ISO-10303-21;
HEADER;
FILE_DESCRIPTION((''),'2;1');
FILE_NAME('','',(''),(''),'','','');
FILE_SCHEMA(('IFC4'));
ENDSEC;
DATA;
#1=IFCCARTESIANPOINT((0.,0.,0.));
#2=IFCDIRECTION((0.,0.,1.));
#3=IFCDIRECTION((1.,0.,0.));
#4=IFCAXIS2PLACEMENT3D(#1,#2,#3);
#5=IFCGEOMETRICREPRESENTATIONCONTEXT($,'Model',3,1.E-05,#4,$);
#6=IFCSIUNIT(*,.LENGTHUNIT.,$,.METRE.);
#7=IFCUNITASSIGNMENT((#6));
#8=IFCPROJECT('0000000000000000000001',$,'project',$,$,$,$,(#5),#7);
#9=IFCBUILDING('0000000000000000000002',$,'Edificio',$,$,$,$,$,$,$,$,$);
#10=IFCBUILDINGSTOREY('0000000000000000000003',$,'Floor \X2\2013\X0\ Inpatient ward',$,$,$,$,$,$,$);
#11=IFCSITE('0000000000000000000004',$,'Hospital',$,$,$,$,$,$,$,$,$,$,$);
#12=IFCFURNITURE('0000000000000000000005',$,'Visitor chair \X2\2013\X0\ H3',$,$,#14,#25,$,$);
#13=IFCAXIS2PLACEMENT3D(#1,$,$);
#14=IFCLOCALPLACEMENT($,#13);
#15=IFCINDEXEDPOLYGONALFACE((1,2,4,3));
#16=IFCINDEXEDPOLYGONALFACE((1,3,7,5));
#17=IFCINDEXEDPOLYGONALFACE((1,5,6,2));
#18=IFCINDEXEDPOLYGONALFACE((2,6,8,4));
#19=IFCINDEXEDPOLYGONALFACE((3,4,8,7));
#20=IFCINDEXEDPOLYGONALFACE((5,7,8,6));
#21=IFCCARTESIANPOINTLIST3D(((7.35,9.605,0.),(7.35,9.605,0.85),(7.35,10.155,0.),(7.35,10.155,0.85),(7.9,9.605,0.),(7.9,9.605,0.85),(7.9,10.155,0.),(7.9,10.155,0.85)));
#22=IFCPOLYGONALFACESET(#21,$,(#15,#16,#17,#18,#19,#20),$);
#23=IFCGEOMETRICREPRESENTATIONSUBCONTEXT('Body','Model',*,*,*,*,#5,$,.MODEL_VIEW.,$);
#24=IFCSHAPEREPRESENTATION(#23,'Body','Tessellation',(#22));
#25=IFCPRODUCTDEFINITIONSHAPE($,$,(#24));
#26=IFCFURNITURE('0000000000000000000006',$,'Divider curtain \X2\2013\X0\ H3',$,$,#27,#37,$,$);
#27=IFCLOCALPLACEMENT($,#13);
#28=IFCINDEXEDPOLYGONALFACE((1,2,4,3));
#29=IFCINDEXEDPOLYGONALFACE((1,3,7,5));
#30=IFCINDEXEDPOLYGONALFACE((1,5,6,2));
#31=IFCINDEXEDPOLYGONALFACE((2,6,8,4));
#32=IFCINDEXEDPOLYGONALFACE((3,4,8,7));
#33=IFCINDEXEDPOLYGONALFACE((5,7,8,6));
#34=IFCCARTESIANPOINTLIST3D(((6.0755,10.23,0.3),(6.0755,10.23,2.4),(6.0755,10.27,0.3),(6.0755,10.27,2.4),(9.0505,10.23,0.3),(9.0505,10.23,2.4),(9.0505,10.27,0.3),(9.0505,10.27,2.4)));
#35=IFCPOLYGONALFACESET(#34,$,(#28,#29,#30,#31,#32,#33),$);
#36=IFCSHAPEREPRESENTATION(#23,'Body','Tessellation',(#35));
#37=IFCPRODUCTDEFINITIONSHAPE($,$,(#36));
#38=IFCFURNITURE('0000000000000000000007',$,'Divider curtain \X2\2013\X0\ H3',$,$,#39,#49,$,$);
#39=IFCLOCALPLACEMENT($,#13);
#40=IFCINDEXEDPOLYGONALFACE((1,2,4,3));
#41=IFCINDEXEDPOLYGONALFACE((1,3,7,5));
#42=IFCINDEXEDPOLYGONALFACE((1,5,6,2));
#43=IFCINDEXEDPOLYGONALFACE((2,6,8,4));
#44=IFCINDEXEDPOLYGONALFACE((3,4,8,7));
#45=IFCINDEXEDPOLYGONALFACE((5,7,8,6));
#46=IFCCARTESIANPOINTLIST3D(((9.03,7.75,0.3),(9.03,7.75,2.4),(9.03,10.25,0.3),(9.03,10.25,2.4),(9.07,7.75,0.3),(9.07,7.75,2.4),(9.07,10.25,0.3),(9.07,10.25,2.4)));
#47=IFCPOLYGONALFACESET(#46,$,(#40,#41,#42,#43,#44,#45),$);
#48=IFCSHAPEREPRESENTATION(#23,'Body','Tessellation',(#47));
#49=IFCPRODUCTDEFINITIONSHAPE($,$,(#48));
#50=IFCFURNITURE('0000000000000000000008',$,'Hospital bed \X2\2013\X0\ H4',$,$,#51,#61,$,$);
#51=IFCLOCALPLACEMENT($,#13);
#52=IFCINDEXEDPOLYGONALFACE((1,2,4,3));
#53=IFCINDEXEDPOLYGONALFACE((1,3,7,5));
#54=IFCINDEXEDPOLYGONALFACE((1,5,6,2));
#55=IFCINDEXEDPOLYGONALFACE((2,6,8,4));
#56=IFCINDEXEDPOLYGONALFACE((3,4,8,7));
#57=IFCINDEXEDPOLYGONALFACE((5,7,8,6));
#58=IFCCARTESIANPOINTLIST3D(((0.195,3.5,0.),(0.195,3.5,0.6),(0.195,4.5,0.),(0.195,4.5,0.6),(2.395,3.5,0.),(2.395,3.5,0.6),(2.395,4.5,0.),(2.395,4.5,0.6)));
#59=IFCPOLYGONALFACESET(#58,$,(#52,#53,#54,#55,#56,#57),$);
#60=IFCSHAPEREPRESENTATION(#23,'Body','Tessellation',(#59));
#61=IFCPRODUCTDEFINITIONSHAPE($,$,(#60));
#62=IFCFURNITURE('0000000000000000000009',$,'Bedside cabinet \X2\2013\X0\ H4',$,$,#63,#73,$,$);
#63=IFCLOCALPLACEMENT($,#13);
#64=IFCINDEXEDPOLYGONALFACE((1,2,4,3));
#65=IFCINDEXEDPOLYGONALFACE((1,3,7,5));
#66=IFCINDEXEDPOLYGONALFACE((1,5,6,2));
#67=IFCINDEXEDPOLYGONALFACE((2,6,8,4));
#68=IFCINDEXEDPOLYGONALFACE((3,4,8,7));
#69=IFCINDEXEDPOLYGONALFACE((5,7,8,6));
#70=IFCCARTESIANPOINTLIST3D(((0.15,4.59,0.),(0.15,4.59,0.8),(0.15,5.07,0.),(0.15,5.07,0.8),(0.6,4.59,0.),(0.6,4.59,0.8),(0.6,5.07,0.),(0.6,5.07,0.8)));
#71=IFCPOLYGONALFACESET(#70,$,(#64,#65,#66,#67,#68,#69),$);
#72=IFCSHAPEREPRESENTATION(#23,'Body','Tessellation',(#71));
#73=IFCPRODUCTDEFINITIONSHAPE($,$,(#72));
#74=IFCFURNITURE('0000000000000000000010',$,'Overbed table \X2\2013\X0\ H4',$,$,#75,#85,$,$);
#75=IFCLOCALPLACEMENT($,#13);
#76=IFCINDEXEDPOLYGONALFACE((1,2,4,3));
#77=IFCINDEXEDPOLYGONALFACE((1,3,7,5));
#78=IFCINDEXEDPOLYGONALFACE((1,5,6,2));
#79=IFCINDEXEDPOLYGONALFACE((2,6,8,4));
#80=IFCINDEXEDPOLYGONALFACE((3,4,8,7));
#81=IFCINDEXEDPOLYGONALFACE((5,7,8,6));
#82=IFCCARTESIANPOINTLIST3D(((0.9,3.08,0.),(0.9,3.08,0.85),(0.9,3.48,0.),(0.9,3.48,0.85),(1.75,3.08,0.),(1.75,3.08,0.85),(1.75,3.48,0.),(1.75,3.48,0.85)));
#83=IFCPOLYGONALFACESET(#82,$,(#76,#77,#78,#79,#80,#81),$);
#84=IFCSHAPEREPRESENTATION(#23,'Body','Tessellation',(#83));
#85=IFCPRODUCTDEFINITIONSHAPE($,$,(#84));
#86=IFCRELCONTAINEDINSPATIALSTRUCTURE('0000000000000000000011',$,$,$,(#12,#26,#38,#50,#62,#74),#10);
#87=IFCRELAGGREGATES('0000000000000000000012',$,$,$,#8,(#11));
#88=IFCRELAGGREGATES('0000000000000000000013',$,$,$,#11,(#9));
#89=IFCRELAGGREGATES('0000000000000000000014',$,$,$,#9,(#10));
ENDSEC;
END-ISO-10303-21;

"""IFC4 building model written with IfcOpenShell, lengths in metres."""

from ifc_helpers import new_model, si_unit, frame, origin_with_axes, context, subcontext, project, spatial, line, indexed_curve, outline, extrude, element, save


model = new_model("IFC4")

# Units and contexts
model_context = context("Model", 3, precision=1e-05, world=origin_with_axes())
body_context = subcontext(model_context, "Body", "Model", "MODEL_VIEW")
ifc_project = project(units=[si_unit("LENGTHUNIT", "METRE")], contexts=[model_context])

# Site, building, storey
site = spatial("IfcSite", under=ifc_project, Name="Hospital")
building = spatial("IfcBuilding", under=site, Name="Edificio")
storey = spatial("IfcBuildingStorey", under=building, Name="Floor – Inpatient ward")

# Furniture
element("IfcFurniture", 1, inside=storey, Name="Visitor chair – H3", context=body_context, shape_type="SweptSolid", body=[
    extrude(outline(indexed_curve([(0.0, 0.0), (0.55, 0.0), (0.55, 0.55), (0.0, 0.55)], segments=[line(1, 2, 3, 4, 1)])), frame((7.35, 9.605, 0.0), z_axis=(0.0, 0.0, 1.0), x_axis=(1.0, 0.0, 0.0)), (0.0, 0.0, 1.0), 0.85),
])
element("IfcFurniture", 2, inside=storey, Name="Divider curtain – H3", context=body_context, shape_type="SweptSolid", body=[
    extrude(outline(indexed_curve([(0.0, 0.0), (2.975, 0.0), (2.975, 0.04), (0.0, 0.04)], segments=[line(1, 2, 3, 4, 1)])), frame((6.0755, 10.23, 0.3), z_axis=(0.0, 0.0, 1.0), x_axis=(1.0, 0.0, 0.0)), (0.0, 0.0, 1.0), 2.1),
])
element("IfcFurniture", 3, inside=storey, Name="Divider curtain – H3", context=body_context, shape_type="SweptSolid", body=[
    extrude(outline(indexed_curve([(0.0, 0.0), (0.04, 0.0), (0.04, 2.5), (0.0, 2.5)], segments=[line(1, 2, 3, 4, 1)])), frame((9.03, 7.75, 0.3), z_axis=(0.0, 0.0, 1.0), x_axis=(1.0, 0.0, 0.0)), (0.0, 0.0, 1.0), 2.1),
])
element("IfcFurniture", 4, inside=storey, Name="Hospital bed – H4", context=body_context, shape_type="SweptSolid", body=[
    extrude(outline(indexed_curve([(0.0, 0.0), (2.2, 0.0), (2.2, 1.0), (0.0, 1.0)], segments=[line(1, 2, 3, 4, 1)])), frame((0.195, 3.5, 0.0), z_axis=(0.0, 0.0, 1.0), x_axis=(1.0, 0.0, 0.0)), (0.0, 0.0, 1.0), 0.6),
])
element("IfcFurniture", 5, inside=storey, Name="Bedside cabinet – H4", context=body_context, shape_type="SweptSolid", body=[
    extrude(outline(indexed_curve([(0.0, 0.0), (0.45, 0.0), (0.45, 0.48), (0.0, 0.48)], segments=[line(1, 2, 3, 4, 1)])), frame((0.15, 4.59, 0.0), z_axis=(0.0, 0.0, 1.0), x_axis=(1.0, 0.0, 0.0)), (0.0, 0.0, 1.0), 0.8),
])
element("IfcFurniture", 6, inside=storey, Name="Overbed table – H4", context=body_context, shape_type="SweptSolid", body=[
    extrude(outline(indexed_curve([(0.0, 0.0), (0.85, 0.0), (0.85, 0.4), (0.0, 0.4)], segments=[line(1, 2, 3, 4, 1)])), frame((0.9, 3.08, 0.0), z_axis=(0.0, 0.0, 1.0), x_axis=(1.0, 0.0, 0.0)), (0.0, 0.0, 1.0), 0.85),
])

save(model, "model.ifc")
